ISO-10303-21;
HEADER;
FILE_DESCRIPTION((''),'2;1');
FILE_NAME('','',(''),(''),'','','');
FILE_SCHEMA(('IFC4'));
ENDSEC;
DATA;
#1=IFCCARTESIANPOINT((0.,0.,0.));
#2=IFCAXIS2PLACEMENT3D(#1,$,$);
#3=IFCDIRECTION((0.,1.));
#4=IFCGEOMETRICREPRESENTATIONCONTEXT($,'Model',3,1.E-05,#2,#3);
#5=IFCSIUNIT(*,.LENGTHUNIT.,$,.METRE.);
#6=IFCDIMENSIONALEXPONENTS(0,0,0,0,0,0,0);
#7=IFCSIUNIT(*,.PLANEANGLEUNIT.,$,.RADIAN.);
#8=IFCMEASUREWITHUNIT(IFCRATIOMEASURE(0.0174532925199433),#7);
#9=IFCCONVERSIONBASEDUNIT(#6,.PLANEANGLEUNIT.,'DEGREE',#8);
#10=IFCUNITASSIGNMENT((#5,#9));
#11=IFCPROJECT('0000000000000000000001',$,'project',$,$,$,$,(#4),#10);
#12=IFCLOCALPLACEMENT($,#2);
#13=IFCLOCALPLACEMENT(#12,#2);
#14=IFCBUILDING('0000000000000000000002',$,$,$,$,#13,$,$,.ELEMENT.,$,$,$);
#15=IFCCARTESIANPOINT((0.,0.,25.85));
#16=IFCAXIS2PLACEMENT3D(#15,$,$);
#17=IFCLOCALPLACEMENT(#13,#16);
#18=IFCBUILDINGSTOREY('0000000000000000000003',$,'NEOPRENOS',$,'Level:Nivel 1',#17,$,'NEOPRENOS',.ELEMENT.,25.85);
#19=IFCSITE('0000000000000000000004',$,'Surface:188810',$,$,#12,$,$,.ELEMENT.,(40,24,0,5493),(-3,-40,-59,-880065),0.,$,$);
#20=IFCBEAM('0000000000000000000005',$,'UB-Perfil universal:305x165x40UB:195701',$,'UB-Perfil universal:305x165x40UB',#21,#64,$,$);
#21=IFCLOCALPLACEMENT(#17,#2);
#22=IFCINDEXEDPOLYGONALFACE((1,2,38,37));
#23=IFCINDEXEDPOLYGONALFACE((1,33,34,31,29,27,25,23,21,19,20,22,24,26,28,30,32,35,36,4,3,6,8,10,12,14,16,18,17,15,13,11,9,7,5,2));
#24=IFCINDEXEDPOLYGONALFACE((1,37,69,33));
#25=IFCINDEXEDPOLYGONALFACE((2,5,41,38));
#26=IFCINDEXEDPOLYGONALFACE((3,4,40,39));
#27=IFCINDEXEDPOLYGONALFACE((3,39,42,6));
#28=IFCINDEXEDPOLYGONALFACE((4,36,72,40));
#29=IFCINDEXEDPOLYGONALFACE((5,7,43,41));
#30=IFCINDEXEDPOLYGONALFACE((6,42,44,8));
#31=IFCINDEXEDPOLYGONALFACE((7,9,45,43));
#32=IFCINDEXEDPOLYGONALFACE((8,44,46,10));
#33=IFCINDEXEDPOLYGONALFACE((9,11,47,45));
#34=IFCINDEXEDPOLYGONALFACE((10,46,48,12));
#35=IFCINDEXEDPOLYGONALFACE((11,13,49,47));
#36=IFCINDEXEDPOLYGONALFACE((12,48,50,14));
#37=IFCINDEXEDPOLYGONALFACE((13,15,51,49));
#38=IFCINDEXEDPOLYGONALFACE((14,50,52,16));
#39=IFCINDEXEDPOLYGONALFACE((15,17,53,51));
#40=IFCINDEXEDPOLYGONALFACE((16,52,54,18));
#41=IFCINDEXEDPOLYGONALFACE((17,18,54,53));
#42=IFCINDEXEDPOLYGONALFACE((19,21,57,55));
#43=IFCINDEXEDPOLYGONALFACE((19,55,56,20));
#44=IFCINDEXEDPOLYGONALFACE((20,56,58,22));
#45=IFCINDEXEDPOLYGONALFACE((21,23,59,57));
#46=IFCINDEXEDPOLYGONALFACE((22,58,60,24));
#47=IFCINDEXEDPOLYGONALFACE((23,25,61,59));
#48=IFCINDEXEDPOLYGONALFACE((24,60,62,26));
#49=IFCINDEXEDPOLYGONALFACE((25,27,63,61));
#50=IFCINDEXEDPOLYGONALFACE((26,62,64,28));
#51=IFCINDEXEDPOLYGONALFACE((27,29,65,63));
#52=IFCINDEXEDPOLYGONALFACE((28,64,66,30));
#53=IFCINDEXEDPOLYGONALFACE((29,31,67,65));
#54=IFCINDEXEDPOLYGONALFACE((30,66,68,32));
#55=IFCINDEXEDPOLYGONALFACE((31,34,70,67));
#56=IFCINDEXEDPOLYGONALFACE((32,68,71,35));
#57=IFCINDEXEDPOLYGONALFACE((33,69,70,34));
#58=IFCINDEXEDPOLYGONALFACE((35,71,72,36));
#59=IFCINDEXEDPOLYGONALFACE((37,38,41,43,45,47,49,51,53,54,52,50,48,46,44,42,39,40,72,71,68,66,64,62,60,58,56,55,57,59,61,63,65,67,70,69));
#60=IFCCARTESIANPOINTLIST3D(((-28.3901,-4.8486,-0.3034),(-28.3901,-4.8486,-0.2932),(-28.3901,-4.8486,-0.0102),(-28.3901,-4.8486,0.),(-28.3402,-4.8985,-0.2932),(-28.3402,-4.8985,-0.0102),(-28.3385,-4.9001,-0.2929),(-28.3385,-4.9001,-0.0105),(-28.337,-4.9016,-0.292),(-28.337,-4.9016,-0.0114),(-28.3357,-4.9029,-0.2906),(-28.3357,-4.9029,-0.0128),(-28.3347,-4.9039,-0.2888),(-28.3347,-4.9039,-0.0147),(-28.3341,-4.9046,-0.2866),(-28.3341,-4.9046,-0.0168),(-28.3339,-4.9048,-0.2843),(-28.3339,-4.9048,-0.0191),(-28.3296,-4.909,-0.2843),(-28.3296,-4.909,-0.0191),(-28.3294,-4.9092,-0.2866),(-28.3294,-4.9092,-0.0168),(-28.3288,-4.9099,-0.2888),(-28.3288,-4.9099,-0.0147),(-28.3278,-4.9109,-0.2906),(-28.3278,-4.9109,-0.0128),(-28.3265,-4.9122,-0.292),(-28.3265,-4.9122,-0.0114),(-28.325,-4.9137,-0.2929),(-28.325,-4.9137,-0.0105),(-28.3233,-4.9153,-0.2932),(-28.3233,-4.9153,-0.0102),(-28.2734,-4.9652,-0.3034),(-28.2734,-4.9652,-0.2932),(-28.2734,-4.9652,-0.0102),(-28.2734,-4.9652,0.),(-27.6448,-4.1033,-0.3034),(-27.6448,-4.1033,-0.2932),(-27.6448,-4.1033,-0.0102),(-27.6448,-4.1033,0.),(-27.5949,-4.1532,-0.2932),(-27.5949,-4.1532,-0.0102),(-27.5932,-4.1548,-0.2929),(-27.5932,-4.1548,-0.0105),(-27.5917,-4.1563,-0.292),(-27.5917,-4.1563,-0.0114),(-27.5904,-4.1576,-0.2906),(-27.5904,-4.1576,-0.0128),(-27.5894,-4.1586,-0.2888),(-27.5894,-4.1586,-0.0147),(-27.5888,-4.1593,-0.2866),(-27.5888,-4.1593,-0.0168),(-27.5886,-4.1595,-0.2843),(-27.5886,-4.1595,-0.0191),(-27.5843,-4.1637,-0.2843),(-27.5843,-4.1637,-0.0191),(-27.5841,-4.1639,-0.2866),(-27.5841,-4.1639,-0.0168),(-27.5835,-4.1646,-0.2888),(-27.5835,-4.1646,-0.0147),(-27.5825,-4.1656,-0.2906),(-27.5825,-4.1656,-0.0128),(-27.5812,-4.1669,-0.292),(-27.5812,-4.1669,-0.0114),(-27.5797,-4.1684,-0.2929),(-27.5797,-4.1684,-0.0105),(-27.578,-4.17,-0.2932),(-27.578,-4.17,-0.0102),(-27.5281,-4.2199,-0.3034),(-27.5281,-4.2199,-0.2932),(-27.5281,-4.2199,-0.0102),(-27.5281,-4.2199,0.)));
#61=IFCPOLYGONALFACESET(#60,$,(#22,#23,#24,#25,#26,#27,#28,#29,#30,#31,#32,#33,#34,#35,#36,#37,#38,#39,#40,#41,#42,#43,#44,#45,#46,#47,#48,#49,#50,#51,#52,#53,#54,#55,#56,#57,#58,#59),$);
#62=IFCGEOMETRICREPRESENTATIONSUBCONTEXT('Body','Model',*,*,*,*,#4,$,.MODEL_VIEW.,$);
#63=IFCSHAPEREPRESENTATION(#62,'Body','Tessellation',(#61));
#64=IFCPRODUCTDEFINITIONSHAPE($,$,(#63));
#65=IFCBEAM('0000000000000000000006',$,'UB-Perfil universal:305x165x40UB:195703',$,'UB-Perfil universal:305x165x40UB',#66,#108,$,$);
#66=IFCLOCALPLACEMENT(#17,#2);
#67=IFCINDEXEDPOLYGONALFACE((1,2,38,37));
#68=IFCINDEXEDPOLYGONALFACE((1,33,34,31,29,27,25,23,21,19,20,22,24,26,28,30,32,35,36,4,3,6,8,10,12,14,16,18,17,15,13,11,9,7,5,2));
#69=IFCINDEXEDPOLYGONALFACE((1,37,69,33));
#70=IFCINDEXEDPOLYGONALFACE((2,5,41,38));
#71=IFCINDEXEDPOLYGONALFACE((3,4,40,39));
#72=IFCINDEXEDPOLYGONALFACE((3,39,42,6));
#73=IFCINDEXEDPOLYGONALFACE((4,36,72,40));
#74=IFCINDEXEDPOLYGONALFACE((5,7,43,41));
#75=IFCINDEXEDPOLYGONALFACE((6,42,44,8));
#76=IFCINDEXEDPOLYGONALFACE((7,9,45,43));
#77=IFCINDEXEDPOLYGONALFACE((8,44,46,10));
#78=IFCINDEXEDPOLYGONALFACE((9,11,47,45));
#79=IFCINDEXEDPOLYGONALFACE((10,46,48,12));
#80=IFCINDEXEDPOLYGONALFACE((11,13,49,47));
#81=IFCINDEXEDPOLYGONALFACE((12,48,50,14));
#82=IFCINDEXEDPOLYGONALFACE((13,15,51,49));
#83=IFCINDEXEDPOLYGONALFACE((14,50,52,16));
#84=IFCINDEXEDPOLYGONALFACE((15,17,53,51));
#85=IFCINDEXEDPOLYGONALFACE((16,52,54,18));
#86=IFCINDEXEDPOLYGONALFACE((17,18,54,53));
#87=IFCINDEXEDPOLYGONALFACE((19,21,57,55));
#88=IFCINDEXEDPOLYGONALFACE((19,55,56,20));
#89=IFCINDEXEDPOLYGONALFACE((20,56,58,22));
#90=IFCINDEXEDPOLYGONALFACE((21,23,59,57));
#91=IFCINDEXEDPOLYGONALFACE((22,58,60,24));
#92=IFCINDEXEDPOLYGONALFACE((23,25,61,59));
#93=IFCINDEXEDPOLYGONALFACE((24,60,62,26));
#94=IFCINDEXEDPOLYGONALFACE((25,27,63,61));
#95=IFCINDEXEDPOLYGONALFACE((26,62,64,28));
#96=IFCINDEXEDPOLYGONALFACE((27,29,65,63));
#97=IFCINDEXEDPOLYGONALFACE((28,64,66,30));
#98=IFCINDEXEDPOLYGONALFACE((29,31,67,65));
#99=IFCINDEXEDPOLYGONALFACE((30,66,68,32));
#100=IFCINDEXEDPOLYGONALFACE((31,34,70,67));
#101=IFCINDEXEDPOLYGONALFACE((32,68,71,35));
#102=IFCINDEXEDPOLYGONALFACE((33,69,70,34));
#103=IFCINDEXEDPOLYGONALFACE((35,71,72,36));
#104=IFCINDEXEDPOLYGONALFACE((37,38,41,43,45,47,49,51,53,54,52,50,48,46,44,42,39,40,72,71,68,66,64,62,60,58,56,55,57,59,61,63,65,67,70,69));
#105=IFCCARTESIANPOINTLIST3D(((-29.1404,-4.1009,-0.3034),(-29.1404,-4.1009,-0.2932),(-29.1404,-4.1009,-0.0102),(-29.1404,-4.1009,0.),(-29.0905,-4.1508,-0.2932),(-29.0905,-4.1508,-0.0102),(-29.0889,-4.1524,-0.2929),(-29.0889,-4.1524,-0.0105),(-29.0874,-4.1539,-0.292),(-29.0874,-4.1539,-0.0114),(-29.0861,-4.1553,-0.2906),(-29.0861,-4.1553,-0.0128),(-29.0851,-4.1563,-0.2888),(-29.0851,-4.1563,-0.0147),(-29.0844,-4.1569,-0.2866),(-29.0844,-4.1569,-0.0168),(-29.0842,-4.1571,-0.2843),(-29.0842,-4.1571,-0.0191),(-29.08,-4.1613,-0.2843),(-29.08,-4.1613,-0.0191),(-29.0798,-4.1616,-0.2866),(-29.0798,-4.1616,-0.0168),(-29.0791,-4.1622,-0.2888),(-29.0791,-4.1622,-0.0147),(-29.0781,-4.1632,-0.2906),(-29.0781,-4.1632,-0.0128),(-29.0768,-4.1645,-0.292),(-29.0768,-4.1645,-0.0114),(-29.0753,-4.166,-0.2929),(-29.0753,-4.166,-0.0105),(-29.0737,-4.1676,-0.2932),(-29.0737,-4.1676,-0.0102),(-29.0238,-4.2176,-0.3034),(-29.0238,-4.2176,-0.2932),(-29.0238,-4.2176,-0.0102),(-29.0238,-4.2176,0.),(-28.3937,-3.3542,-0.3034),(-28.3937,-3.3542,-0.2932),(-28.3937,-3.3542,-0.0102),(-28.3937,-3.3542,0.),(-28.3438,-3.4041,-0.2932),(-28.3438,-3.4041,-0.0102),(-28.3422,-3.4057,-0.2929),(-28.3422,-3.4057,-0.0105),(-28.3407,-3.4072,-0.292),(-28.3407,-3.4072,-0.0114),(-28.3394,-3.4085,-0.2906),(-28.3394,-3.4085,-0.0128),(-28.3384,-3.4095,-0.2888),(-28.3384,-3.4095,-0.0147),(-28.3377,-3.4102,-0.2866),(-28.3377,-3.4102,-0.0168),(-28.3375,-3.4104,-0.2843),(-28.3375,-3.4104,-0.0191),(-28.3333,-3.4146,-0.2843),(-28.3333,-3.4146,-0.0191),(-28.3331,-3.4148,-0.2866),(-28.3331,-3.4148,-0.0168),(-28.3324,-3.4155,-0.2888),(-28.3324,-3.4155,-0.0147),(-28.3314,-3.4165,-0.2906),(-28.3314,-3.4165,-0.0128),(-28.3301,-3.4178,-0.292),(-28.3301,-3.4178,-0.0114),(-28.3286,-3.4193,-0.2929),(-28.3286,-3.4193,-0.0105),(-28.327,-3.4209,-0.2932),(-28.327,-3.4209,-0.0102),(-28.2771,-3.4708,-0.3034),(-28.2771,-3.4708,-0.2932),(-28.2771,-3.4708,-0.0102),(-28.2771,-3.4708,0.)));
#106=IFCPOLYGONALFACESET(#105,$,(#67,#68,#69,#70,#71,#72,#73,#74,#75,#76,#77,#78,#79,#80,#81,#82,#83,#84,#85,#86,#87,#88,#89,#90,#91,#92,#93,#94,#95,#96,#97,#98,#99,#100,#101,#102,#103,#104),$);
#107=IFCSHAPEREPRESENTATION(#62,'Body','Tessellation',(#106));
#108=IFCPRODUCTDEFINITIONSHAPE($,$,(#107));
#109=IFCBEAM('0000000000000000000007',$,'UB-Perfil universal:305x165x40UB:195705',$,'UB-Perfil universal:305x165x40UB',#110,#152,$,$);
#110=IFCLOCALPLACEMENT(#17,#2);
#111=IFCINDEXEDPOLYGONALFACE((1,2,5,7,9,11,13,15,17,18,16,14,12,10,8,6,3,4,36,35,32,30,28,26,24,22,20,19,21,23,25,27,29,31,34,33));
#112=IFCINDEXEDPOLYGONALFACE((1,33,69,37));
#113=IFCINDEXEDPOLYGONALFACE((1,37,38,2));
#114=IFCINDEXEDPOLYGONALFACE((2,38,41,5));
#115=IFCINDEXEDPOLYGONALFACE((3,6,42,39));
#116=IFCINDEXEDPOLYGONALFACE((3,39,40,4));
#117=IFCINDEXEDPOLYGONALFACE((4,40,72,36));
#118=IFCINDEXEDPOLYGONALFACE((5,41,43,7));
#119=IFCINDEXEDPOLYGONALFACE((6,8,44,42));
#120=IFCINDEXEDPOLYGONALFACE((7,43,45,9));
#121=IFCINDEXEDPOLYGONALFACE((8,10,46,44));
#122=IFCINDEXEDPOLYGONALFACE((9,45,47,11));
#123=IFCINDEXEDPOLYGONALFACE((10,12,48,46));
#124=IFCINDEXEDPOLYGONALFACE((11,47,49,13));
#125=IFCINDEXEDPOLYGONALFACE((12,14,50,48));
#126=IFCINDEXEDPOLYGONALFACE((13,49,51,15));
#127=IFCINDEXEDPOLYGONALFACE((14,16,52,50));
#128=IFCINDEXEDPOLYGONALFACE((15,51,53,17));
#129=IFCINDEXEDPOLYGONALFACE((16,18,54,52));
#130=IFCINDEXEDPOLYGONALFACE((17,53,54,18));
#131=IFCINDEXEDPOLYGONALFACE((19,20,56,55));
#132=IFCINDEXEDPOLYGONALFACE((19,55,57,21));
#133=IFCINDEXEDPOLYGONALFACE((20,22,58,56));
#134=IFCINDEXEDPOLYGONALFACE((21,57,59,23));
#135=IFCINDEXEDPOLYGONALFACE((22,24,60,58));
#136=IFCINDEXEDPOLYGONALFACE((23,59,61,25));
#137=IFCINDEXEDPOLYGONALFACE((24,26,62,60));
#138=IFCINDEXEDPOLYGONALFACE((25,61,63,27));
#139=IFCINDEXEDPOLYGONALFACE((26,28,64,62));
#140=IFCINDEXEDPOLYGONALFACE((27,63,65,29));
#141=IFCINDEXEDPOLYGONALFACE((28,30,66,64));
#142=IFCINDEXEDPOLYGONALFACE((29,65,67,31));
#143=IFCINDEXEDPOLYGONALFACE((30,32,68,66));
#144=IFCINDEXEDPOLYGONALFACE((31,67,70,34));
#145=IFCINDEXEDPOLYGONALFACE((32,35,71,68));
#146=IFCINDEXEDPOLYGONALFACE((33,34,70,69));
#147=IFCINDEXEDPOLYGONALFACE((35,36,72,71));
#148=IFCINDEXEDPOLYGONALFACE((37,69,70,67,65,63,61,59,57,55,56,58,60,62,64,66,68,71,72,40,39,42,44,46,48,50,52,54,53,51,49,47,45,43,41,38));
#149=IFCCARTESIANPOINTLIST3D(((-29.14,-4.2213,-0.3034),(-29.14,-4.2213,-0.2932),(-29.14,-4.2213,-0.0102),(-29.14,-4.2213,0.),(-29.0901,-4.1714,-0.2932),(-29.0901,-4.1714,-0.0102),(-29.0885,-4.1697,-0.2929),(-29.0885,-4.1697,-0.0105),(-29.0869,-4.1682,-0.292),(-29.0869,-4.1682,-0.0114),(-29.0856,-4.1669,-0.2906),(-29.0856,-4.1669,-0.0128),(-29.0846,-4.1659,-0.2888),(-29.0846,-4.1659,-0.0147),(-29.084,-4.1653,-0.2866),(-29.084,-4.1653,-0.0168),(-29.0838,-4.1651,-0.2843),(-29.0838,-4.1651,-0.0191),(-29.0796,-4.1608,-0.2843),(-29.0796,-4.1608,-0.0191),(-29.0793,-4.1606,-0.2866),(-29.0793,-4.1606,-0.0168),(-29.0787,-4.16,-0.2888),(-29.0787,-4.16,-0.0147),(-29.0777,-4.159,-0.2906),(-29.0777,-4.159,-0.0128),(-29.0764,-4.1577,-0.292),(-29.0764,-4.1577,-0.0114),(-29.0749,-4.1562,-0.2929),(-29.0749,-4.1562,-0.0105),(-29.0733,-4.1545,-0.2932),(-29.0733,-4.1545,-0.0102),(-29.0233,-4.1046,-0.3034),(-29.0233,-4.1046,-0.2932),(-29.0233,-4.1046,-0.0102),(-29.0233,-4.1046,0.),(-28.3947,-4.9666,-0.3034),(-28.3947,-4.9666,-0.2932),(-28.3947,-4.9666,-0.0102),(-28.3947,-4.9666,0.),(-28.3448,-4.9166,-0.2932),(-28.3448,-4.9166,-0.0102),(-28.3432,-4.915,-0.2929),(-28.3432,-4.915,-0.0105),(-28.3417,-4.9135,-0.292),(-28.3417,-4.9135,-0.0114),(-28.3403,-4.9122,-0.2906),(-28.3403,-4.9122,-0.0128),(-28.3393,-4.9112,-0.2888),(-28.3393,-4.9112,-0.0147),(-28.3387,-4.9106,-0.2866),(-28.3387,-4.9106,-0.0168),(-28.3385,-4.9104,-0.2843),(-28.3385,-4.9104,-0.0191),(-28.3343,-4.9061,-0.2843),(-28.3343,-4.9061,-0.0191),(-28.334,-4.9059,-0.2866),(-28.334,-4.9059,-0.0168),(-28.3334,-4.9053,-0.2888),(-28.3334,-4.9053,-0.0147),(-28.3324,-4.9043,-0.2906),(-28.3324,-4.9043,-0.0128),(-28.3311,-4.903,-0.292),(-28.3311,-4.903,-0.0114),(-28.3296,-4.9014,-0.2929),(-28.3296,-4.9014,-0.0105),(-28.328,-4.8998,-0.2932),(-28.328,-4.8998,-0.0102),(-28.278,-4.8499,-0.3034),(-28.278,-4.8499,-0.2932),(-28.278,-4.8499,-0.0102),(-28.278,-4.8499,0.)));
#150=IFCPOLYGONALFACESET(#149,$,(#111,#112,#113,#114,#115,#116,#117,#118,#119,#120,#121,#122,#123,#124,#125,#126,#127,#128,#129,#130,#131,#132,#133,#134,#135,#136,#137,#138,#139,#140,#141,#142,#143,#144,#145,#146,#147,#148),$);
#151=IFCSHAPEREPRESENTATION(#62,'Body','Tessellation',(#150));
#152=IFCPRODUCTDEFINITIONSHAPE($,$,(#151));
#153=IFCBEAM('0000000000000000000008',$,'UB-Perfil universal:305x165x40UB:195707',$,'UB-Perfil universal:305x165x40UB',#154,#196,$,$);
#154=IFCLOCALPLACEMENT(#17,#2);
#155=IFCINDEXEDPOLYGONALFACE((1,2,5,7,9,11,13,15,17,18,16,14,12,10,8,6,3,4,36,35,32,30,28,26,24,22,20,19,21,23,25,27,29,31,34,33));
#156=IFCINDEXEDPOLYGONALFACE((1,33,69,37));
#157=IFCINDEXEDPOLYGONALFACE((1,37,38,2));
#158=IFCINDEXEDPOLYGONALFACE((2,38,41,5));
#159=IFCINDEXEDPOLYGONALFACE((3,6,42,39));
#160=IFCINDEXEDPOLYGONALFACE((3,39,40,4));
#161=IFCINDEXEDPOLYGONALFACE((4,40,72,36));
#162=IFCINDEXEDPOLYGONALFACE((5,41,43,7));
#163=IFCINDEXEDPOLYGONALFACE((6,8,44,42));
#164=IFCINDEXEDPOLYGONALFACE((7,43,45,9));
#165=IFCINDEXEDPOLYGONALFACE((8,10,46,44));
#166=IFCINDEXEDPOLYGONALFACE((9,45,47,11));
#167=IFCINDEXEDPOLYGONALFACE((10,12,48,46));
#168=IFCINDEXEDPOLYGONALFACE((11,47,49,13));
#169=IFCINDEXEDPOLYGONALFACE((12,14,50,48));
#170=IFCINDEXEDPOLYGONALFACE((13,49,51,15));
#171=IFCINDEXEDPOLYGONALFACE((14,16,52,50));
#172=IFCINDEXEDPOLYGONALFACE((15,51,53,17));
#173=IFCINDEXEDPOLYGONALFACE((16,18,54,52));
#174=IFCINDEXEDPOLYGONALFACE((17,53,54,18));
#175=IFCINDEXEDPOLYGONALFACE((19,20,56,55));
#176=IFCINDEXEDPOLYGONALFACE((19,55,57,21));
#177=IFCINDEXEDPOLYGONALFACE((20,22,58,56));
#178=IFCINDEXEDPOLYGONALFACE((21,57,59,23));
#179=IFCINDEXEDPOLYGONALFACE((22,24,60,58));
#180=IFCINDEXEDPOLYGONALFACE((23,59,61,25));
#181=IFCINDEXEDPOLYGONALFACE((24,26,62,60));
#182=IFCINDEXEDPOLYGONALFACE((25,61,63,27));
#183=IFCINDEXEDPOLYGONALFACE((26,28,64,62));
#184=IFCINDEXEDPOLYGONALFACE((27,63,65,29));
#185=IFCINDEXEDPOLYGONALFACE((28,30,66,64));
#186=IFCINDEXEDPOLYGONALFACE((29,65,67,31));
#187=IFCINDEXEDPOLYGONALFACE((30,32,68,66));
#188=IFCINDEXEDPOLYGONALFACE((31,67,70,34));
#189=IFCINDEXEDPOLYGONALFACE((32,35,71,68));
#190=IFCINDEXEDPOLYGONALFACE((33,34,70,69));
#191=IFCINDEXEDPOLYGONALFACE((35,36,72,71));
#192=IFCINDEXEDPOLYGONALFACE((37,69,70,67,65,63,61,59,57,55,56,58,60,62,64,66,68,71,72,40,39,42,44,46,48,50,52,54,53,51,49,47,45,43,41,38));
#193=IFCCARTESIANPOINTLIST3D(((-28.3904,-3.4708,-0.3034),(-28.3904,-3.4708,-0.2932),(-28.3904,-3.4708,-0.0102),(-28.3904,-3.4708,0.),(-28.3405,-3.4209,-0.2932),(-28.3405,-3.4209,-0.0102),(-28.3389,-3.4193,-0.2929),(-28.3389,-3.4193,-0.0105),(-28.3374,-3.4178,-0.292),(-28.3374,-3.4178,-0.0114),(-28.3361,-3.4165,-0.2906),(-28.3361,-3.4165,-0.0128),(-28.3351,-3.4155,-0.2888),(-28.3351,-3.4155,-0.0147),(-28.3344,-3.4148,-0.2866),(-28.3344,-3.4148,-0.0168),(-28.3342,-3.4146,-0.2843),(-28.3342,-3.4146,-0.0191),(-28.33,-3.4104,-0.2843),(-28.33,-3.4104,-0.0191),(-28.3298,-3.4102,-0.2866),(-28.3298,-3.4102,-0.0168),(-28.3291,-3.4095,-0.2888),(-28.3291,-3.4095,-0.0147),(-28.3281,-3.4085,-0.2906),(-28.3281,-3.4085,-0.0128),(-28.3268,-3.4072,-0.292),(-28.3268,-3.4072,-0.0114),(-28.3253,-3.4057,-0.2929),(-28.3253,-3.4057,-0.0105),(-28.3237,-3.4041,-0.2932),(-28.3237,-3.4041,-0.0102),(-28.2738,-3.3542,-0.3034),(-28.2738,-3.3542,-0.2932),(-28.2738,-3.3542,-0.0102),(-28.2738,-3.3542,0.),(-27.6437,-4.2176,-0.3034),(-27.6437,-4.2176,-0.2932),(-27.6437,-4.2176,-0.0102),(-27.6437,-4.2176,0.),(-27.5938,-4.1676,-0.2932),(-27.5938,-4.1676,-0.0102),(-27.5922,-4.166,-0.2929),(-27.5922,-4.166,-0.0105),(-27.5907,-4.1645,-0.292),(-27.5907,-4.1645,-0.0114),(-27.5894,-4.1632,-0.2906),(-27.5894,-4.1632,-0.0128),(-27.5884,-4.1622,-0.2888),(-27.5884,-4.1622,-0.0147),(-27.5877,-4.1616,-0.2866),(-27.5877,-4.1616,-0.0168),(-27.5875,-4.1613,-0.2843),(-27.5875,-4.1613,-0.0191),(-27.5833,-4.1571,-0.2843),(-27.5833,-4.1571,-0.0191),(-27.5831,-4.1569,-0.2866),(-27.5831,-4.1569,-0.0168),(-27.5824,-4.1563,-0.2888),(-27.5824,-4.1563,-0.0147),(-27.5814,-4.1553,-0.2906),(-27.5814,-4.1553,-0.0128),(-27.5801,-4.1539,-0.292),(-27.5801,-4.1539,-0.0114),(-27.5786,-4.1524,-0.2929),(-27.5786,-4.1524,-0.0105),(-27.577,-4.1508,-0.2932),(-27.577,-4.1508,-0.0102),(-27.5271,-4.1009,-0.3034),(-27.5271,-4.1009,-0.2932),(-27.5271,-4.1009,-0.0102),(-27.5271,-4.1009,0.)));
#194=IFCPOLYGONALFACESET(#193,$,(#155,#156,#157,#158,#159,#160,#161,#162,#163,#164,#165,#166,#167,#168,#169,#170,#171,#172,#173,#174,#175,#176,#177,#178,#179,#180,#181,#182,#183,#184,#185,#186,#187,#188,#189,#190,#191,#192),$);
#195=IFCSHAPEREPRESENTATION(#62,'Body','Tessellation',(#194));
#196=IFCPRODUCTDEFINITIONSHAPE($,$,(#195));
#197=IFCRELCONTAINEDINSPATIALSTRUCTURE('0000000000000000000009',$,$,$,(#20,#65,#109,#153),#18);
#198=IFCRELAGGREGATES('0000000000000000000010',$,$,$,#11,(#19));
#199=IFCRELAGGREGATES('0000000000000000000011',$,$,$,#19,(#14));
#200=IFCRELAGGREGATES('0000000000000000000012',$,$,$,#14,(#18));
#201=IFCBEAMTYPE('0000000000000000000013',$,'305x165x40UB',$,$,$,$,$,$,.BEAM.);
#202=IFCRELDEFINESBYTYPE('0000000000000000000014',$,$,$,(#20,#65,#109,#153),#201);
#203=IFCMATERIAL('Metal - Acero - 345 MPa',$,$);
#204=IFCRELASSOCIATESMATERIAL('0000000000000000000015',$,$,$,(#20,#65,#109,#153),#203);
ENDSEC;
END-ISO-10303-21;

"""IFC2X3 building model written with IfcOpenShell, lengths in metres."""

from ifc_helpers import new_model, entity, si_unit, converted_unit, direction, frame, frame_2d, origin, place, context, subcontext, project, spatial, i_section, extrude, material, type_object, element, save


model = new_model("IFC2X3")

# Units and contexts
model_context = context("Model", 3, precision=1e-05, world=origin(), true_north=direction((0.0, 1.0)))
body_context = subcontext(model_context, "Body", "Model", "MODEL_VIEW")
ifc_project = project(units=[si_unit("LENGTHUNIT", "METRE"), converted_unit("PLANEANGLEUNIT", "DEGREE", entity("IfcRatioMeasure", 0.0174532925199433), si_unit("PLANEANGLEUNIT", "RADIAN"), dimensions=[0, 0, 0, 0, 0, 0, 0])], contexts=[model_context])

# Site, building, storey
site_placement = place(None, origin())
site = spatial("IfcSite", under=ifc_project, at=site_placement, Name="Surface:188810", CompositionType="ELEMENT", RefLatitude=(40, 24, 0, 5493), RefLongitude=(-3, -40, -59, -880065), RefElevation=0.0)
building_placement = place(site_placement, origin())
building = spatial("IfcBuilding", under=site, at=building_placement, CompositionType="ELEMENT")
storey_placement = place(building_placement, frame((0.0, 0.0, 25.85)))
storey = spatial("IfcBuildingStorey", under=building, at=storey_placement, Name="NEOPRENOS", ObjectType="Level:Nivel 1", LongName="NEOPRENOS", CompositionType="ELEMENT", Elevation=25.85)

# Beams
ifc_material_1 = material(Name="Metal - Acero - 345 MPa")
beam_type = type_object("IfcBeamType", Name="305x165x40UB", PredefinedType="BEAM")
beam_1_placement = place(storey_placement, frame((-28.3337, -4.9089, 0.0), z_axis=(0.0, 0.0, 1.0), x_axis=(0.707107, 0.707107, 0.0)))
element("IfcBeam", 1, at=beam_1_placement, inside=storey, type_object=beam_type, material=ifc_material_1, Name="UB-Perfil universal:305x165x40UB:195701", ObjectType="UB-Perfil universal:305x165x40UB", context=body_context, shape_type="SweptSolid", body=[
    extrude(i_section(OverallWidth=0.165, OverallDepth=0.3034, WebThickness=0.006, FlangeThickness=0.0102, FilletRadius=0.0089, at=frame_2d((0.0, 0.0), x_axis=(0.0, 1.0))), frame((0.0028, 0.0, -0.1517), z_axis=(1.0, 0.0, 0.0), x_axis=(0.0, 0.0, -1.0)), (0.0, 0.0, 1.0), 1.054),
])
beam_2_placement = place(storey_placement, frame((-28.3337, -3.4109, 0.0), z_axis=(0.0, 0.0, 1.0), x_axis=(-0.707107, -0.707107, 0.0)))
element("IfcBeam", 2, at=beam_2_placement, inside=storey, type_object=beam_type, material=ifc_material_1, Name="UB-Perfil universal:305x165x40UB:195703", ObjectType="UB-Perfil universal:305x165x40UB", context=body_context, shape_type="SweptSolid", body=[
    extrude(i_section(OverallWidth=0.165, OverallDepth=0.3034, WebThickness=0.006, FlangeThickness=0.0102, FilletRadius=0.0089, at=frame_2d((0.0, 0.0), x_axis=(0.0, 1.0))), frame((0.0023, 0.0, -0.1517), z_axis=(1.0, 0.0, 0.0), x_axis=(0.0, 0.0, -1.0)), (0.0, 0.0, 1.0), 1.056),
])
beam_3_placement = place(storey_placement, frame((-29.0837, -4.1609, 0.0), z_axis=(0.0, 0.0, 1.0), x_axis=(0.707107, -0.707107, 0.0)))
element("IfcBeam", 3, at=beam_3_placement, inside=storey, type_object=beam_type, material=ifc_material_1, Name="UB-Perfil universal:305x165x40UB:195705", ObjectType="UB-Perfil universal:305x165x40UB", context=body_context, shape_type="SweptSolid", body=[
    extrude(i_section(OverallWidth=0.165, OverallDepth=0.3034, WebThickness=0.006, FlangeThickness=0.0102, FilletRadius=0.0089, at=frame_2d((0.0, 0.0), x_axis=(0.0, 1.0))), frame((0.0029, 0.0, -0.1517), z_axis=(1.0, 0.0, 0.0), x_axis=(0.0, 0.0, -1.0)), (0.0, 0.0, 1.0), 1.054),
])
beam_4_placement = place(storey_placement, frame((-27.5837, -4.1609, 0.0), z_axis=(0.0, 0.0, 1.0), x_axis=(-0.707107, 0.707107, 0.0)))
element("IfcBeam", 4, at=beam_4_placement, inside=storey, type_object=beam_type, material=ifc_material_1, Name="UB-Perfil universal:305x165x40UB:195707", ObjectType="UB-Perfil universal:305x165x40UB", context=body_context, shape_type="SweptSolid", body=[
    extrude(i_section(OverallWidth=0.165, OverallDepth=0.3034, WebThickness=0.006, FlangeThickness=0.0102, FilletRadius=0.0089, at=frame_2d((0.0, 0.0), x_axis=(0.0, 1.0))), frame((0.0023, 0.0, -0.1517), z_axis=(1.0, 0.0, 0.0), x_axis=(0.0, 0.0, -1.0)), (0.0, 0.0, 1.0), 1.056),
])

save(model, "model.ifc")
